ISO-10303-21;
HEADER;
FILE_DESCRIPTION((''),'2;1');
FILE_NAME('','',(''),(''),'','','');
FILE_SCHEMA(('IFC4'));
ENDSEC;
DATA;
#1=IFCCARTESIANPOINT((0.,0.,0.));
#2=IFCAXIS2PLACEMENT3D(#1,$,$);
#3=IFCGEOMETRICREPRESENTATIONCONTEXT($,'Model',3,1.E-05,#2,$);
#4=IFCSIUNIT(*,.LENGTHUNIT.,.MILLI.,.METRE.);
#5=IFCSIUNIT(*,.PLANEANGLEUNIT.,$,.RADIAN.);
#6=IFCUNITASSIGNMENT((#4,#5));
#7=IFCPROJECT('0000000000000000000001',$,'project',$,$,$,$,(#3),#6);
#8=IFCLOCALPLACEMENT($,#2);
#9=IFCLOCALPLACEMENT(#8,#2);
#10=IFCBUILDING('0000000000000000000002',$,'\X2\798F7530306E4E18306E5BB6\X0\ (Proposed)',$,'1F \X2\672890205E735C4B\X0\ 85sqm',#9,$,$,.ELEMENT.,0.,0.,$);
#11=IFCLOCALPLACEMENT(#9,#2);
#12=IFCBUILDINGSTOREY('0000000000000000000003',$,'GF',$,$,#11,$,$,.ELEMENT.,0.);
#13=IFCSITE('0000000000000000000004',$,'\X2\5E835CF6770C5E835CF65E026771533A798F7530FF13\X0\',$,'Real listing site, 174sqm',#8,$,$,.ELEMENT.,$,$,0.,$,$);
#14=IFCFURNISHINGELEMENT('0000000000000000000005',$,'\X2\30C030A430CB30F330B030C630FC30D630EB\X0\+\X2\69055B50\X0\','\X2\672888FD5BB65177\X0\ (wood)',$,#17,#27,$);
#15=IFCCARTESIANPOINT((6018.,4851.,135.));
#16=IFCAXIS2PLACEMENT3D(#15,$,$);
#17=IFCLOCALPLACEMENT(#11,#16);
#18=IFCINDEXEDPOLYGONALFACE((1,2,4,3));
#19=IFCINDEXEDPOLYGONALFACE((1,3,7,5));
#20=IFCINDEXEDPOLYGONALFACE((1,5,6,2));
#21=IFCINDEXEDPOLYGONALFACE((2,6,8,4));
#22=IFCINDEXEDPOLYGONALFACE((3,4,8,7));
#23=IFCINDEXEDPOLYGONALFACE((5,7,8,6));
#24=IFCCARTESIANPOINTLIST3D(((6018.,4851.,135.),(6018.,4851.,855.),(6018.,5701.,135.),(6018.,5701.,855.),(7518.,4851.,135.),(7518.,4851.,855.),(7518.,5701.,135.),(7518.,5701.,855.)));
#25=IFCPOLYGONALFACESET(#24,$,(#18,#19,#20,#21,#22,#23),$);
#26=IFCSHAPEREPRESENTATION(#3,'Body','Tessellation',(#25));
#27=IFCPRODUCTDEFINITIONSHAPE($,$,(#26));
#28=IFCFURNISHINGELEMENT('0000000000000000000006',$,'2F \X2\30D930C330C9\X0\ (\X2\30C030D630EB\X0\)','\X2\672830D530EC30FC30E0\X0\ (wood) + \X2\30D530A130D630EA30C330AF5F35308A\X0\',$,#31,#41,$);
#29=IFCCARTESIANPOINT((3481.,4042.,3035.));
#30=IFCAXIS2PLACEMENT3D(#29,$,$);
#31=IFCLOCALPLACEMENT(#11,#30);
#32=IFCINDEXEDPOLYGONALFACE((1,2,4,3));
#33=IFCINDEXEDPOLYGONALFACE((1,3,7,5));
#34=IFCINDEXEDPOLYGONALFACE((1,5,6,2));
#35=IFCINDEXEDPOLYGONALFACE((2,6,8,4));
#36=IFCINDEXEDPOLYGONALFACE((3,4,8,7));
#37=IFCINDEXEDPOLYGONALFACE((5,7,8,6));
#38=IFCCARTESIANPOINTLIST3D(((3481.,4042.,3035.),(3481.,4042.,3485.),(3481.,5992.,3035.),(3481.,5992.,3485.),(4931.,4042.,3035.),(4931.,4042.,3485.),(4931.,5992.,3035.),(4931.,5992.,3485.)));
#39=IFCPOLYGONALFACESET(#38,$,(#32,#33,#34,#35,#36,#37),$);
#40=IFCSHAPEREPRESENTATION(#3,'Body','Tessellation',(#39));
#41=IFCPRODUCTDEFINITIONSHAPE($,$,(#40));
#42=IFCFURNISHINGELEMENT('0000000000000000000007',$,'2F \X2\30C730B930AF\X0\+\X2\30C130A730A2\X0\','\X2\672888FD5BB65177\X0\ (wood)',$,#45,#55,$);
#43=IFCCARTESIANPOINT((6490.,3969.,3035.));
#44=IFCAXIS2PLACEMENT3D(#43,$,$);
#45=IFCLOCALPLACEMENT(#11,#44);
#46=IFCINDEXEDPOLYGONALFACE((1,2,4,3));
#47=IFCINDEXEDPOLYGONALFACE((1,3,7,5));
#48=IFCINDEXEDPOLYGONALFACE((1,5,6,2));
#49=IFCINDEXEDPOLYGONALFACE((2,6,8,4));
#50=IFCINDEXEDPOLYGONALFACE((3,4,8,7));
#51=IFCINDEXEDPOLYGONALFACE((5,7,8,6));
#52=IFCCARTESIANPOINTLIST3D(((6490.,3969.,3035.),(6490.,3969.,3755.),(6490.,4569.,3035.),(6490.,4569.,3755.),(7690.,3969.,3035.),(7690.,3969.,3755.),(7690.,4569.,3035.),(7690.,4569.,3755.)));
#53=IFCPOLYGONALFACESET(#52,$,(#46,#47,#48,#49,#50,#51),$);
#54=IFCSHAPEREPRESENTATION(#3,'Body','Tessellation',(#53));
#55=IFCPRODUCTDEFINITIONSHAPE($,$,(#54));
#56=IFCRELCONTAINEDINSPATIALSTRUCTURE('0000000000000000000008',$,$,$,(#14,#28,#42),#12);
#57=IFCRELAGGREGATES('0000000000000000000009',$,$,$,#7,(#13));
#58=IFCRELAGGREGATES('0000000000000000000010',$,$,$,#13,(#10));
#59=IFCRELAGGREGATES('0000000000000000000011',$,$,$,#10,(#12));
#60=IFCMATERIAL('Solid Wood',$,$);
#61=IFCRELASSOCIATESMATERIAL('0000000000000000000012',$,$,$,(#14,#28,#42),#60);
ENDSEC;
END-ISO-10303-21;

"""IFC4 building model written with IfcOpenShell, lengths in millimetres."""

from ifc_helpers import new_model, si_unit, frame, frame_2d, origin, place, context, project, spatial, rectangle, extrude, material, element, save


model = new_model("IFC4")

# Units and contexts
model_context = context("Model", 3, precision=1e-05, world=origin())
ifc_project = project(units=[si_unit("LENGTHUNIT", "METRE", prefix="MILLI"), si_unit("PLANEANGLEUNIT", "RADIAN")], contexts=[model_context])

# Site, building, storey
site_placement = place(None, origin())
site = spatial("IfcSite", under=ifc_project, at=site_placement, Name="広島県広島市東区福田３", ObjectType="Real listing site, 174sqm", CompositionType="ELEMENT", RefElevation=0.0)
building_placement = place(site_placement, origin())
building = spatial("IfcBuilding", under=site, at=building_placement, Name="福田の丘の家 (Proposed)", ObjectType="1F 木造平屋 85sqm", CompositionType="ELEMENT", ElevationOfRefHeight=0.0, ElevationOfTerrain=0.0)
storey_placement = place(building_placement, origin())
storey = spatial("IfcBuildingStorey", under=building, at=storey_placement, Name="GF", CompositionType="ELEMENT", Elevation=0.0)

# Shared definitions
ifc_material_1 = material(Name="Solid Wood")

# Furnishing elements
furnishing_1_placement = place(storey_placement, frame((6018.0, 4851.0, 135.0)))
element("IfcFurnishingElement", 1, at=furnishing_1_placement, inside=storey, material=ifc_material_1, Name="ダイニングテーブル+椅子", Description="木製家具 (wood)", context=model_context, shape_type="SweptSolid", body=[
    extrude(rectangle(XDim=1500.0, YDim=850.0, at=frame_2d((750.0, 425.0))), frame((6018.0, 4851.0, 135.0)), (0.0, 0.0, 1.0), 720.0),
])
furnishing_2_placement = place(storey_placement, frame((3481.0, 4042.0, 3035.0)))
element("IfcFurnishingElement", 2, at=furnishing_2_placement, inside=storey, material=ifc_material_1, Name="2F ベッド (ダブル)", Description="木フレーム (wood) + ファブリック張り", context=model_context, shape_type="SweptSolid", body=[
    extrude(rectangle(XDim=1450.0, YDim=1950.0, at=frame_2d((725.0, 975.0))), frame((3481.0, 4042.0, 3035.0)), (0.0, 0.0, 1.0), 450.0),
])
furnishing_3_placement = place(storey_placement, frame((6490.0, 3969.0, 3035.0)))
element("IfcFurnishingElement", 3, at=furnishing_3_placement, inside=storey, material=ifc_material_1, Name="2F デスク+チェア", Description="木製家具 (wood)", context=model_context, shape_type="SweptSolid", body=[
    extrude(rectangle(XDim=1200.0, YDim=600.0, at=frame_2d((600.0, 300.0))), frame((6490.0, 3969.0, 3035.0)), (0.0, 0.0, 1.0), 720.0),
])

save(model, "model.ifc")
